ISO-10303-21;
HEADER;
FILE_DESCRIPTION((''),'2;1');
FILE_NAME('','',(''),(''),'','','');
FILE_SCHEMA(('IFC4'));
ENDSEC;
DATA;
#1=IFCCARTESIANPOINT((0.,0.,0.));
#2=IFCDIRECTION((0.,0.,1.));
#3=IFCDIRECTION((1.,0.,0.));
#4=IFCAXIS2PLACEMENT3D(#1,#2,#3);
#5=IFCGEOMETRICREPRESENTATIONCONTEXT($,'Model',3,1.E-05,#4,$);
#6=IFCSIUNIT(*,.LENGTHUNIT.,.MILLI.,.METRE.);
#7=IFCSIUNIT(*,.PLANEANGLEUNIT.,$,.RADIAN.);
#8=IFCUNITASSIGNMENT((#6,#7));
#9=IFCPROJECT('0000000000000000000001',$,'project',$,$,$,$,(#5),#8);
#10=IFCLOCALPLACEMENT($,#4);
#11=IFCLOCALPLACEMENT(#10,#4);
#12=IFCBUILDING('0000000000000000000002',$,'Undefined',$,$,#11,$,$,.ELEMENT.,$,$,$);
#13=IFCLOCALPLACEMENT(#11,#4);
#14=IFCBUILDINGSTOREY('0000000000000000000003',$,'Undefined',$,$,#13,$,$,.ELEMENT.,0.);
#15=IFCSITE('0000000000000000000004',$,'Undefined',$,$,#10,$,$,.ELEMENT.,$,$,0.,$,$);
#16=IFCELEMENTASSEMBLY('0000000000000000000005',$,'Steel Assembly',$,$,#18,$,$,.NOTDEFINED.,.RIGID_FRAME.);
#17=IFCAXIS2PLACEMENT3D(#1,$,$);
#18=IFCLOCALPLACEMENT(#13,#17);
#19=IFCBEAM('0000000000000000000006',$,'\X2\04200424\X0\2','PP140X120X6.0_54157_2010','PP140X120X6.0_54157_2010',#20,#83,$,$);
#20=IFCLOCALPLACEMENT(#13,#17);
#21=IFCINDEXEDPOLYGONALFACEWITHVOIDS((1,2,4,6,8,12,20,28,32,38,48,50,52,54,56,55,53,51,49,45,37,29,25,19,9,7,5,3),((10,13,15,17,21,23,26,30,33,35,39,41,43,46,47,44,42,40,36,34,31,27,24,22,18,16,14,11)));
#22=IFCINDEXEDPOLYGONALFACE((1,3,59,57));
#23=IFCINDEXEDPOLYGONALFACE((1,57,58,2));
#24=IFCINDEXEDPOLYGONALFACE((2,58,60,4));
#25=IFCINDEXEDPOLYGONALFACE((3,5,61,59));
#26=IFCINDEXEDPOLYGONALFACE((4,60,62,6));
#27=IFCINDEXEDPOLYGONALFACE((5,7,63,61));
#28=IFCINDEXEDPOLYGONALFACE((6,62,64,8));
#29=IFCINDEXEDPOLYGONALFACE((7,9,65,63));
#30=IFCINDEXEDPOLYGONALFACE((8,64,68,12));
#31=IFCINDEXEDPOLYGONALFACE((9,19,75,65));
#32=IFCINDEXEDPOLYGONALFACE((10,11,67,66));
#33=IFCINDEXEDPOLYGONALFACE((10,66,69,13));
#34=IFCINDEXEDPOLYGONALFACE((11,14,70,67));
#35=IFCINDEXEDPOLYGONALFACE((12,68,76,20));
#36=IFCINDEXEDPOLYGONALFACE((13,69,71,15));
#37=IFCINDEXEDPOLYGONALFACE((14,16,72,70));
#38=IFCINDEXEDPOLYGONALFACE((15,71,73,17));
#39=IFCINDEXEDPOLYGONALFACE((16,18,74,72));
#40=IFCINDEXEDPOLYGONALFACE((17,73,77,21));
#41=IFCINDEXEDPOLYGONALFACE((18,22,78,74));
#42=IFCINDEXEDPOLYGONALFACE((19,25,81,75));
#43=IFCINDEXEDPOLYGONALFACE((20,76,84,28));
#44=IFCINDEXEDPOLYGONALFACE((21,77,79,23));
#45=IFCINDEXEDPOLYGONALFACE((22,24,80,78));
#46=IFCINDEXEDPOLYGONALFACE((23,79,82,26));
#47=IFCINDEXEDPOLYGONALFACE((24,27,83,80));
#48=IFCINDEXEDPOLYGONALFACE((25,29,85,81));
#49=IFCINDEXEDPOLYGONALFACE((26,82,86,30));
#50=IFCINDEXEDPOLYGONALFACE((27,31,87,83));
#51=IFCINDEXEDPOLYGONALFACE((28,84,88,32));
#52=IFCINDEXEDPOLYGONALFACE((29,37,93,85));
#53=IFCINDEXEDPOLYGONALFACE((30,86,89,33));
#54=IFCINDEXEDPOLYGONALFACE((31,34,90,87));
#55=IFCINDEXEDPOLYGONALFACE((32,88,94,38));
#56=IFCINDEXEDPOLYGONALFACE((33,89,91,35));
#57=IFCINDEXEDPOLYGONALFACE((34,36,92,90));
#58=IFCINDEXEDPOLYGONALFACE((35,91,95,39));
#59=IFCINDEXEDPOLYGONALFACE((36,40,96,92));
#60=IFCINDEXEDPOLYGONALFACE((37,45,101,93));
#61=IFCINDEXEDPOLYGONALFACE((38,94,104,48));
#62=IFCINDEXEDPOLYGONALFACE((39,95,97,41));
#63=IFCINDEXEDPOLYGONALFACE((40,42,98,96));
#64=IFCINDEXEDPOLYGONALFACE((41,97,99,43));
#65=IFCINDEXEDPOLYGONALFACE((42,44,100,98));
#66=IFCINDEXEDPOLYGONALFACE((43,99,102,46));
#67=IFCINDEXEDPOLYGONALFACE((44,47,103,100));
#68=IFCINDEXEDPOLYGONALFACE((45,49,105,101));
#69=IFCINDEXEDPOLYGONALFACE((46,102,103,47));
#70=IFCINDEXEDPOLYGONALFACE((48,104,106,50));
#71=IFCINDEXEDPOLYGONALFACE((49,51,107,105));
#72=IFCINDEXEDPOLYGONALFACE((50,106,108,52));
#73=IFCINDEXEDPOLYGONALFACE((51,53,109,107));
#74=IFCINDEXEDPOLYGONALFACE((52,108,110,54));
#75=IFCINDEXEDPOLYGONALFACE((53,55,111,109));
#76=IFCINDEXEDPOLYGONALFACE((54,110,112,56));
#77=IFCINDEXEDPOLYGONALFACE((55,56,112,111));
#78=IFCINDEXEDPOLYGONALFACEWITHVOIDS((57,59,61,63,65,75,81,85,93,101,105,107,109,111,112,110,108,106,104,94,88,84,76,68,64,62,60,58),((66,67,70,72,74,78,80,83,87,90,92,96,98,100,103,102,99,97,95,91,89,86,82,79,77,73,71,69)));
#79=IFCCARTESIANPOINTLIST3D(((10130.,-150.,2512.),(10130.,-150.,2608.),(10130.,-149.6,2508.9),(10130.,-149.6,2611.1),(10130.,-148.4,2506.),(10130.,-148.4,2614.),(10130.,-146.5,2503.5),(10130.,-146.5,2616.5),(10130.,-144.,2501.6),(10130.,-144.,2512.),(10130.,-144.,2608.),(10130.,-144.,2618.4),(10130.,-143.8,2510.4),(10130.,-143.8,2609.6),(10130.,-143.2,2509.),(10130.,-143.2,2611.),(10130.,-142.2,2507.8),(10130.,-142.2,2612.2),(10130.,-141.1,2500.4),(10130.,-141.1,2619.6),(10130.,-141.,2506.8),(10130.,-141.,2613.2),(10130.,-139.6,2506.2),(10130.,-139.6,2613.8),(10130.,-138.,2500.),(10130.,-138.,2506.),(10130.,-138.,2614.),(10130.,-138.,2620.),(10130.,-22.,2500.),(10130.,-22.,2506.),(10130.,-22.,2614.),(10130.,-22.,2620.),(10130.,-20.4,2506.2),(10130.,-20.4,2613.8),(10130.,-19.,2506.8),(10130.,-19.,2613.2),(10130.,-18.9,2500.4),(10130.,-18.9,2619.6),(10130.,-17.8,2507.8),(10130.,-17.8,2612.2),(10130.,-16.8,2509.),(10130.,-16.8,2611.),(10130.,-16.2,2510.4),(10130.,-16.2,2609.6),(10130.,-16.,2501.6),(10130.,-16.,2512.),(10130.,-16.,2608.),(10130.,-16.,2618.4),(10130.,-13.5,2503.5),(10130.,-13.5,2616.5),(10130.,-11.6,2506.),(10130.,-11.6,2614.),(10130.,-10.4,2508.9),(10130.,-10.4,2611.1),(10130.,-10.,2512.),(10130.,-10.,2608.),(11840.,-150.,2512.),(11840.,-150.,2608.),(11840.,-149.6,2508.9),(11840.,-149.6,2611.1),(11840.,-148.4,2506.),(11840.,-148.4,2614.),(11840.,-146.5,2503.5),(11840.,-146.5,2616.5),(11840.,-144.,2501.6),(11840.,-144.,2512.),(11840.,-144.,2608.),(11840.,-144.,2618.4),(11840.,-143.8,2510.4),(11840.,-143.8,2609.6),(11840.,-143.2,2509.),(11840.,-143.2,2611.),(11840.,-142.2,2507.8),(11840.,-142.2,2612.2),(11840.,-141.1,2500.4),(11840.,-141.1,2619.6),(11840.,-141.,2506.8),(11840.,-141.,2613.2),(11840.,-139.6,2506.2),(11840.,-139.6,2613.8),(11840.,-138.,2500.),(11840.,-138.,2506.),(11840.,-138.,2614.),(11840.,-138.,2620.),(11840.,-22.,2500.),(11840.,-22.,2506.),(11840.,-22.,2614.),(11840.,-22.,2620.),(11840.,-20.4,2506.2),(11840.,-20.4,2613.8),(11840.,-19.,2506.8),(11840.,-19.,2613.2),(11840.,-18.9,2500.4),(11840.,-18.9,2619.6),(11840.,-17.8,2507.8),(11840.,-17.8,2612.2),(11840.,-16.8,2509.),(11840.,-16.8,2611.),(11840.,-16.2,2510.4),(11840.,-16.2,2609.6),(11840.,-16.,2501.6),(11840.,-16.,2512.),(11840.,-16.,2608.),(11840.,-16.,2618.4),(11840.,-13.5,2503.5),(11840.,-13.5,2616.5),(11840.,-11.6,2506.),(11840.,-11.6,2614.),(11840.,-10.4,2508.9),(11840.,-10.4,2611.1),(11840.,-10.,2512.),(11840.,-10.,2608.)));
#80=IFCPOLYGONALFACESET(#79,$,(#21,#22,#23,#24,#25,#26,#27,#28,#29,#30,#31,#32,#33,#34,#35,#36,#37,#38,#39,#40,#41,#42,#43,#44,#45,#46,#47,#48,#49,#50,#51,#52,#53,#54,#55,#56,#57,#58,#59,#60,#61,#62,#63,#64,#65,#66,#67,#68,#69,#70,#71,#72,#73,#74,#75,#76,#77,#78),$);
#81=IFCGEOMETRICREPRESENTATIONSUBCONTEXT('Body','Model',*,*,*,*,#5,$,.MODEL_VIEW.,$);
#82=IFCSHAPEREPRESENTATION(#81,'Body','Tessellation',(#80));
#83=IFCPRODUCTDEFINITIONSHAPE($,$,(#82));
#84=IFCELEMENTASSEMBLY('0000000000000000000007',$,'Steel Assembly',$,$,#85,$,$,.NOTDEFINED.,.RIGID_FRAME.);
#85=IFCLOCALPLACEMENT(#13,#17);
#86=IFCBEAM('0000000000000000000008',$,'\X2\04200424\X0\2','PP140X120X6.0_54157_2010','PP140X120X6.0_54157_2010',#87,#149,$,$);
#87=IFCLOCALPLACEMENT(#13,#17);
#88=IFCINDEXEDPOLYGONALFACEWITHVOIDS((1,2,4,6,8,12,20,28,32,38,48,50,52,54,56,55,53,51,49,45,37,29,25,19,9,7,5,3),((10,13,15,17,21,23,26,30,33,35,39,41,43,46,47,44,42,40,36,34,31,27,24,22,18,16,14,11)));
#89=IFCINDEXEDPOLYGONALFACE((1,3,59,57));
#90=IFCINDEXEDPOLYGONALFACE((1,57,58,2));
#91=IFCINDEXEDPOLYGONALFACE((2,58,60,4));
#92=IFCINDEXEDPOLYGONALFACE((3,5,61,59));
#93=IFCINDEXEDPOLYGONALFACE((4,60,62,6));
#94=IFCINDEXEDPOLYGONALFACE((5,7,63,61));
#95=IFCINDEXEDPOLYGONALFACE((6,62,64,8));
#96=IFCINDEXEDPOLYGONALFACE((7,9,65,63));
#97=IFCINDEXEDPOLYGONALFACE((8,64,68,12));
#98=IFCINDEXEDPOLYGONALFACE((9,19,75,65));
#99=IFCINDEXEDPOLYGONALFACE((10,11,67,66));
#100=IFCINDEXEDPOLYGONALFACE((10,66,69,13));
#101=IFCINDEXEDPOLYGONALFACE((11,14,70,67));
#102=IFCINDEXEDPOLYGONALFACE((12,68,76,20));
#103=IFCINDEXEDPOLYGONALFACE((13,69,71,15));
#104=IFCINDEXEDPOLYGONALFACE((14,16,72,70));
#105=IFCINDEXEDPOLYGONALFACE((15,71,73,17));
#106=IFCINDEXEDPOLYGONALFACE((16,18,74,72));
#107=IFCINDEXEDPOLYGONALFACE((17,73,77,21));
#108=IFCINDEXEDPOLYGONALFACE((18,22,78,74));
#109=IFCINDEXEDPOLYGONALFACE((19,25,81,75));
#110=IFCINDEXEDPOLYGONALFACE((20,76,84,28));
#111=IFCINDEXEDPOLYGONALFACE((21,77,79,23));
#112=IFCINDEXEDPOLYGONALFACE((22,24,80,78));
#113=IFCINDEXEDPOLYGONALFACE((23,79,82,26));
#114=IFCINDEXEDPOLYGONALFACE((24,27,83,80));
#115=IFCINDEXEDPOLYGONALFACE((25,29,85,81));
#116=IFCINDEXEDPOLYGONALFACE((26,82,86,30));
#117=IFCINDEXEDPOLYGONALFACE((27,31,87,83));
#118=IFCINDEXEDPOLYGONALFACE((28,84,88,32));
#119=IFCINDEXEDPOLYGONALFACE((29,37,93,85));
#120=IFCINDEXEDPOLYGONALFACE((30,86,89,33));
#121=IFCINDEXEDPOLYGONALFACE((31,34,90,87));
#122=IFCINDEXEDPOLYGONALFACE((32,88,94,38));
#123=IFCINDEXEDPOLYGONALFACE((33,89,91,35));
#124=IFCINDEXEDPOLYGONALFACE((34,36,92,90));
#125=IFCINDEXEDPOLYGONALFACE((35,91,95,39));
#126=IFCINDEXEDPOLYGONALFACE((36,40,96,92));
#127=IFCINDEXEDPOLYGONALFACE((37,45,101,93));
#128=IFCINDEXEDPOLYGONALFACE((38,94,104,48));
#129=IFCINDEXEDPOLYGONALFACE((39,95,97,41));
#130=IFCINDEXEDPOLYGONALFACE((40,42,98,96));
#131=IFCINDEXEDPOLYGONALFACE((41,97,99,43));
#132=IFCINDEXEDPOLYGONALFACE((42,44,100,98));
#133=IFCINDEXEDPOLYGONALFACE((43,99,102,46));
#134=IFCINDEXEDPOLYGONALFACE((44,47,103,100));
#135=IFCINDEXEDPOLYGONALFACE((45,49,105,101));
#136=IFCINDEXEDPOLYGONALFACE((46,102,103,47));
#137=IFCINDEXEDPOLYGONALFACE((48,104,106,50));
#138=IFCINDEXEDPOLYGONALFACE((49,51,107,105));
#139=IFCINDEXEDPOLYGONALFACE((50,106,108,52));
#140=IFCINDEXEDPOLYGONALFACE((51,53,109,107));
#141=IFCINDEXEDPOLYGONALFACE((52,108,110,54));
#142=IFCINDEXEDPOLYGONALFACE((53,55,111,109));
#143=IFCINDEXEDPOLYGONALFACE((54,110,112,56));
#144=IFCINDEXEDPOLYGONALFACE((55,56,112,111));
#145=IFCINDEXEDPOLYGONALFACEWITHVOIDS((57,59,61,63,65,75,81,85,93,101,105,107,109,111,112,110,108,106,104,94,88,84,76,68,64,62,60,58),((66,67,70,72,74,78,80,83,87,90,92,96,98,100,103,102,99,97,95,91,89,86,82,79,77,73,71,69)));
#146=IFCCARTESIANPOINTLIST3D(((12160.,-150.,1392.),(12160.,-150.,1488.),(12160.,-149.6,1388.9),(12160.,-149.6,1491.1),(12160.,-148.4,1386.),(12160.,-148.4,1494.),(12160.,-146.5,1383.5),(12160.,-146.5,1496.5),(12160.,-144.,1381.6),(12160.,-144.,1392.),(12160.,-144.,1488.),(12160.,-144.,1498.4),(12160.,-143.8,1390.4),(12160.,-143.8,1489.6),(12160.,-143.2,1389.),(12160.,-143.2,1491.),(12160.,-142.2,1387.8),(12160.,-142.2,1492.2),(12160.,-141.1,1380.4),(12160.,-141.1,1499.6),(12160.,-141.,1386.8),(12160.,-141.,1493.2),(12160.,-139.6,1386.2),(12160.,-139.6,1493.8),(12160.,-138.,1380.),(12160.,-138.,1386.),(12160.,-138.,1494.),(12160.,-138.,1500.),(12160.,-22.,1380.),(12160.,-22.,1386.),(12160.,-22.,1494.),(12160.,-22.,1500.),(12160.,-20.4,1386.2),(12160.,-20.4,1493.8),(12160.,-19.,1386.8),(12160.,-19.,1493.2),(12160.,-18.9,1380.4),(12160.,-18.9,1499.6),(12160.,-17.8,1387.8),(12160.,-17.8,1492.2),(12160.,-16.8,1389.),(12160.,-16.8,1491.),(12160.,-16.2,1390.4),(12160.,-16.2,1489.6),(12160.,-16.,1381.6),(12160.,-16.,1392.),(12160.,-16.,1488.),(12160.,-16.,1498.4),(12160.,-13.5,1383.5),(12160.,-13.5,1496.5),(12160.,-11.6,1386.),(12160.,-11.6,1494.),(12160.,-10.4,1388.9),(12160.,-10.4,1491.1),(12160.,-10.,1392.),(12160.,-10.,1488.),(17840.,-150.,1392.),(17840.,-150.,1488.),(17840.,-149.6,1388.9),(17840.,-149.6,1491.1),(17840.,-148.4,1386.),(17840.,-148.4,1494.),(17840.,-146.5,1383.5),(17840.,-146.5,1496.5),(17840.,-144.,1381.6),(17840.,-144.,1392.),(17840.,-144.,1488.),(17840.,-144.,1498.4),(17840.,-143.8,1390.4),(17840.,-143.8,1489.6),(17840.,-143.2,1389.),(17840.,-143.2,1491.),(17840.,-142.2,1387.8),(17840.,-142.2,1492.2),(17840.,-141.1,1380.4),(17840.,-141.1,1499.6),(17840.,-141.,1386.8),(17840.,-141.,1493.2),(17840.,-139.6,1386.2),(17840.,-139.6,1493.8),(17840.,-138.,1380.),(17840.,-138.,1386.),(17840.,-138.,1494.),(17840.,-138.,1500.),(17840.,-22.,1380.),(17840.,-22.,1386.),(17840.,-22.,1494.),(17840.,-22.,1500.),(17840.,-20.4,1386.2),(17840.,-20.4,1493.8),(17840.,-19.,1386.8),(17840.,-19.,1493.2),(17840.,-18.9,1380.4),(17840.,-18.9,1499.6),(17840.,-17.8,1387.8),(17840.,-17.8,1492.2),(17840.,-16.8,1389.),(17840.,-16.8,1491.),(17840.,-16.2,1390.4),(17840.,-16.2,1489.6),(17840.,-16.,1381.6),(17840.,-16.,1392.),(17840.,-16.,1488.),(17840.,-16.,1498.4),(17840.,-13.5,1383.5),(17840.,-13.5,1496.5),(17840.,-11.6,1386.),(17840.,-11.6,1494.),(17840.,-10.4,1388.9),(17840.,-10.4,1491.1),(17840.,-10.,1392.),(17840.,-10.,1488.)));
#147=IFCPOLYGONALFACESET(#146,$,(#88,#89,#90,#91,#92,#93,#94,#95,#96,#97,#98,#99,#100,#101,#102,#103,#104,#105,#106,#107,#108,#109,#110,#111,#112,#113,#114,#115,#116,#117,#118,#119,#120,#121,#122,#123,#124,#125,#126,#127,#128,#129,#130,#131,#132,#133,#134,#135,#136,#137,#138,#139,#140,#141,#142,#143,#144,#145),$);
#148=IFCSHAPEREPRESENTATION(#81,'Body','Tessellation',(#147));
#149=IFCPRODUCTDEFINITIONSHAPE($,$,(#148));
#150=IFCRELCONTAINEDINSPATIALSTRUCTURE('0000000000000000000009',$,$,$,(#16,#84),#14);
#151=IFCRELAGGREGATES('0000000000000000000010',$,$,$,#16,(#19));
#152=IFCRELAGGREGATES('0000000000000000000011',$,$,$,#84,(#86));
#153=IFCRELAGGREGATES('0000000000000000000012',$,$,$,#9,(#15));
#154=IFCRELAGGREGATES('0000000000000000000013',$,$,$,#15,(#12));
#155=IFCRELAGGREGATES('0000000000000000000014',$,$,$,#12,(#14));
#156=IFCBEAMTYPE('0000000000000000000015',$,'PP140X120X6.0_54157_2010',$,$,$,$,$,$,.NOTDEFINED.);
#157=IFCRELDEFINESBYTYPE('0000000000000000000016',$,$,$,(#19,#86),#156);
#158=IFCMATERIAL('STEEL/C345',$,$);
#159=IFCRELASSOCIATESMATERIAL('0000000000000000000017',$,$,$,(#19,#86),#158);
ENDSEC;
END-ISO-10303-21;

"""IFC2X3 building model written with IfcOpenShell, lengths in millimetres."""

from ifc_helpers import new_model, si_unit, frame, origin_with_axes, origin_2d_with_axis, place, context, subcontext, project, spatial, hollow_rectangle, extrude, material, type_object, element, aggregate, save


model = new_model("IFC2X3")

# Units and contexts
model_context = context("Model", 3, precision=1e-05, world=origin_with_axes())
body_context = subcontext(model_context, "Body", "Model", "MODEL_VIEW")
ifc_project = project(units=[si_unit("LENGTHUNIT", "METRE", prefix="MILLI"), si_unit("PLANEANGLEUNIT", "RADIAN")], contexts=[model_context])

# Site, building, storey
site_placement = place(None, origin_with_axes())
site = spatial("IfcSite", under=ifc_project, at=site_placement, Name="Undefined", CompositionType="ELEMENT", RefElevation=0.0)
building_placement = place(site_placement, origin_with_axes())
building = spatial("IfcBuilding", under=site, at=building_placement, Name="Undefined", CompositionType="ELEMENT")
storey_placement = place(building_placement, origin_with_axes())
storey = spatial("IfcBuildingStorey", under=building, at=storey_placement, Name="Undefined", CompositionType="ELEMENT", Elevation=0.0)

# Shared definitions
ifc_material_1 = material(Name="STEEL/C345")

# Element assemblies, beams
beam_type_1 = type_object("IfcBeamType", Name="PP140X120X6.0_54157_2010", PredefinedType="NOTDEFINED")
assembly_1_placement = place(storey_placement, origin_with_axes())
assembly_1 = element("IfcElementAssembly", 1, at=assembly_1_placement, inside=storey, Name="Steel Assembly", AssemblyPlace="NOTDEFINED", PredefinedType="RIGID_FRAME")
beam_1_placement = place(assembly_1_placement, frame((11840.0, -80.0, 2560.0), z_axis=(0.0, 1.0, 0.0), x_axis=(-1.0, 0.0, 0.0)))
beam_1 = element("IfcBeam", 2, at=beam_1_placement, type_object=beam_type_1, material=ifc_material_1, Name="РФ2", Description="PP140X120X6.0_54157_2010", ObjectType="PP140X120X6.0_54157_2010", context=body_context, shape_type="SweptSolid", body=[
    extrude(hollow_rectangle(XDim=120.0, YDim=140.0, WallThickness=6.0, InnerFilletRadius=6.0, OuterFilletRadius=12.0, at=origin_2d_with_axis()), frame((1710.0, 0.0, 0.0), z_axis=(-1.0, 0.0, 0.0), x_axis=(0.0, -1.0, 0.0)), (0.0, 0.0, 1.0), 1710.0),
])
aggregate(assembly_1, [beam_1])
assembly_2_placement = place(storey_placement, origin_with_axes())
assembly_2 = element("IfcElementAssembly", 3, at=assembly_2_placement, inside=storey, Name="Steel Assembly", AssemblyPlace="NOTDEFINED", PredefinedType="RIGID_FRAME")
beam_2_placement = place(assembly_2_placement, frame((17840.0, -80.0, 1440.0), z_axis=(0.0, 1.0, 0.0), x_axis=(-1.0, 0.0, 0.0)))
beam_2 = element("IfcBeam", 4, at=beam_2_placement, type_object=beam_type_1, material=ifc_material_1, Name="РФ2", Description="PP140X120X6.0_54157_2010", ObjectType="PP140X120X6.0_54157_2010", context=body_context, shape_type="SweptSolid", body=[
    extrude(hollow_rectangle(XDim=120.0, YDim=140.0, WallThickness=6.0, InnerFilletRadius=6.0, OuterFilletRadius=12.0, at=origin_2d_with_axis()), frame((5680.0, 0.0, 0.0), z_axis=(-1.0, 0.0, 0.0), x_axis=(0.0, -1.0, 0.0)), (0.0, 0.0, 1.0), 5680.0),
])
aggregate(assembly_2, [beam_2])

save(model, "model.ifc")
